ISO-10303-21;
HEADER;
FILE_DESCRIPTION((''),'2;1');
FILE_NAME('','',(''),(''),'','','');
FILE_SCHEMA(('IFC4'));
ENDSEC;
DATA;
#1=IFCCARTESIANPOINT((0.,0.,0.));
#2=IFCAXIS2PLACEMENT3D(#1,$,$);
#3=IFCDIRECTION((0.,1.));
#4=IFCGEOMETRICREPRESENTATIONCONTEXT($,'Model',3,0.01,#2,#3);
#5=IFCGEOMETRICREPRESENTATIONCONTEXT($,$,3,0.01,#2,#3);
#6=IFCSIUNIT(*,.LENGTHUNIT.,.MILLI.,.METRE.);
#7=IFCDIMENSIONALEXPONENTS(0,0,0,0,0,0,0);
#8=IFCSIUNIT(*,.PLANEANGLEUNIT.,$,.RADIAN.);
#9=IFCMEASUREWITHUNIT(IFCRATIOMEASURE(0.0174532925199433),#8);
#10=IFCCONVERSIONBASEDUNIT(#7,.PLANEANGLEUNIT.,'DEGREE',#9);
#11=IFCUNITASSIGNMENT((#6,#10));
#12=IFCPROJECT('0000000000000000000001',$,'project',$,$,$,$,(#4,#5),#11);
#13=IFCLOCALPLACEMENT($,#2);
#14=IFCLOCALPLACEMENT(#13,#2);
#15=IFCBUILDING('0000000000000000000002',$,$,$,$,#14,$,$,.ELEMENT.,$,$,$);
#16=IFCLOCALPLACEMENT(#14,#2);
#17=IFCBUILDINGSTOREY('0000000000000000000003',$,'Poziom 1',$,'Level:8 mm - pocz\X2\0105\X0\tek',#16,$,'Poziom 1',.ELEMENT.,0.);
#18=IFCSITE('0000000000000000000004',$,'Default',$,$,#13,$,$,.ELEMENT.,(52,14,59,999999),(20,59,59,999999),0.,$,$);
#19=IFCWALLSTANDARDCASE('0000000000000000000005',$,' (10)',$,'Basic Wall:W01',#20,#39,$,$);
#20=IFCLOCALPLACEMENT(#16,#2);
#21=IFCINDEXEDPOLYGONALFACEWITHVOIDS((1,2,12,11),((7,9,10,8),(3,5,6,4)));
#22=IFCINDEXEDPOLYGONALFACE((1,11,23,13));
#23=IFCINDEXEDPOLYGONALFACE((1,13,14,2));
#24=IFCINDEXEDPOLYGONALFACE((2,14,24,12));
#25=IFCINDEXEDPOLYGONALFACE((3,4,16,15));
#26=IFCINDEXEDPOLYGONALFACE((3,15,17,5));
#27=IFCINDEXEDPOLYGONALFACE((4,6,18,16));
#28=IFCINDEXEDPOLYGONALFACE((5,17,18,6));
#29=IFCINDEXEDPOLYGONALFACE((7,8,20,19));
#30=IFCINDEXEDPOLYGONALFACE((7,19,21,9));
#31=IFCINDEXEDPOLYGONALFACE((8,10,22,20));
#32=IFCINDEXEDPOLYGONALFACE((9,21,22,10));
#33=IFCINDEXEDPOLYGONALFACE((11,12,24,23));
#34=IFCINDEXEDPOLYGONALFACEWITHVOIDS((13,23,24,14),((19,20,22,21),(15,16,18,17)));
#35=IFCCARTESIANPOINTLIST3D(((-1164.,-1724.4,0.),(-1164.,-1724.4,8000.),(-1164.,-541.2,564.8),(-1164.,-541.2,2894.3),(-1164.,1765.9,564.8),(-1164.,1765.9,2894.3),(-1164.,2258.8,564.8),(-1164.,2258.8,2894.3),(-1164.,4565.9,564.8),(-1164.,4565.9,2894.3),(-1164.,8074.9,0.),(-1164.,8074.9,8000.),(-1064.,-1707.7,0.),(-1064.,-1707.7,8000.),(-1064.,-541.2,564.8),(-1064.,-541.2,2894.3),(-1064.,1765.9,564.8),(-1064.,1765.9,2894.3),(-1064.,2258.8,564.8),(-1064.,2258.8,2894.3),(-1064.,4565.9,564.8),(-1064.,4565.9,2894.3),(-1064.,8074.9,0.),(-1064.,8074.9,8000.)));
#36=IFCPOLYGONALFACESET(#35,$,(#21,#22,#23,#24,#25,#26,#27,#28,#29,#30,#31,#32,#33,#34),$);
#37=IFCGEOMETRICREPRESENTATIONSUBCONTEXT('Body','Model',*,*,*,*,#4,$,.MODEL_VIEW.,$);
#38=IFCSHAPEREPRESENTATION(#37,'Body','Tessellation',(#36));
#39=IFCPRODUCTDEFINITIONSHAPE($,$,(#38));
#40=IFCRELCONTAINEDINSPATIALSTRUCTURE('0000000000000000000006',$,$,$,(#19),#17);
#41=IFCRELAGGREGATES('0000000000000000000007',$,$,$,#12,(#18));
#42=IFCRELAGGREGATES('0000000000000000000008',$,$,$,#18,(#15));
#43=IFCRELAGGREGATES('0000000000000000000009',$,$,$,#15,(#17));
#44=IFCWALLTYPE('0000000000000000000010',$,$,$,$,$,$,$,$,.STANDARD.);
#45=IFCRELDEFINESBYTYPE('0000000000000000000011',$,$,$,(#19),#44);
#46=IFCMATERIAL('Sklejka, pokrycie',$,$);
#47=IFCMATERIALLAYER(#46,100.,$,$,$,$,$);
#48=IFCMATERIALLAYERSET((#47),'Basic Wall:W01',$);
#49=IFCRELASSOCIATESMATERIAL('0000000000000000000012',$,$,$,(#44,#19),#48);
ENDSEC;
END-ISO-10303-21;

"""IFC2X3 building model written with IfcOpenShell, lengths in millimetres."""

from ifc_helpers import new_model, entity, si_unit, converted_unit, direction, frame, origin, origin_2d_with_axis, place, context, subcontext, project, spatial, polyline, rectangle, outline, extrude, material, layer, layer_set, layer_usage, type_object, element, save


model = new_model("IFC2X3")

# Units and contexts
model_context = context("Model", 3, precision=0.01, world=origin(), true_north=direction((0.0, 1.0)))
context_of_model = context(None, 3, precision=0.01, world=origin(), true_north=direction((0.0, 1.0)))
body_context = subcontext(model_context, "Body", "Model", "MODEL_VIEW")
ifc_project = project(units=[si_unit("LENGTHUNIT", "METRE", prefix="MILLI"), converted_unit("PLANEANGLEUNIT", "DEGREE", entity("IfcRatioMeasure", 0.0174532925199433), si_unit("PLANEANGLEUNIT", "RADIAN"), dimensions=[0, 0, 0, 0, 0, 0, 0])], contexts=[model_context, context_of_model])

# Site, building, storey
site_placement = place(None, origin())
site = spatial("IfcSite", under=ifc_project, at=site_placement, Name="Default", CompositionType="ELEMENT", RefLatitude=(52, 14, 59, 999999), RefLongitude=(20, 59, 59, 999999), RefElevation=0.0)
building_placement = place(site_placement, origin())
building = spatial("IfcBuilding", under=site, at=building_placement, CompositionType="ELEMENT")
storey_placement = place(building_placement, origin())
storey = spatial("IfcBuildingStorey", under=building, at=storey_placement, Name="Poziom 1", ObjectType="Level:8 mm - początek", LongName="Poziom 1", CompositionType="ELEMENT", Elevation=0.0)

# Wall, openings
ifc_material_1 = material(Name="Sklejka, pokrycie")
ifc_layer_1 = layer(ifc_material_1, 100.0)
ifc_layer_set_1 = layer_set([ifc_layer_1], Name="Basic Wall:W01")
ifc_layer_usage_1 = layer_usage(ifc_layer_set_1, "AXIS2", "NEGATIVE", 50.0)
wall_type_1 = type_object("IfcWallType", PredefinedType="STANDARD", material=ifc_layer_set_1)
wall_1_placement = place(storey_placement, frame((-1114.0, -1724.4, 0.0), z_axis=(0.0, 0.0, 1.0), x_axis=(0.0, 1.0, 0.0)))
wall_1 = element("IfcWallStandardCase", 1, at=wall_1_placement, inside=storey, type_object=wall_type_1, material=ifc_layer_usage_1, Name=" (10)", ObjectType="Basic Wall:W01", context=body_context, shape_type="SweptSolid", body=[
    extrude(outline(polyline([(9799.3, -50.0), (9799.3, 50.0), (0.0, 50.0), (16.7, -50.0), (9799.3, -50.0)])), origin(), (0.0, 0.0, 1.0), 8000.0),
])
opening_1_placement = place(wall_1_placement, origin())
element("IfcOpeningElement", 2, at=opening_1_placement, cuts=wall_1, ObjectType="Opening", context=body_context, shape_type="SweptSolid", body=[
    extrude(rectangle(XDim=2329.5, YDim=2307.1, at=origin_2d_with_axis()), frame((2336.8, -50.0, 1729.5), z_axis=(0.0, 1.0, 0.0), x_axis=(0.0, 0.0, -1.0)), (0.0, 0.0, 1.0), 100.0),
])
opening_2_placement = place(wall_1_placement, origin())
element("IfcOpeningElement", 3, at=opening_2_placement, cuts=wall_1, ObjectType="Opening", context=body_context, shape_type="SweptSolid", body=[
    extrude(rectangle(XDim=2329.5, YDim=2307.1, at=origin_2d_with_axis()), frame((5136.8, -50.0, 1729.5), z_axis=(0.0, 1.0, 0.0), x_axis=(0.0, 0.0, -1.0)), (0.0, 0.0, 1.0), 100.0),
])

save(model, "model.ifc")
